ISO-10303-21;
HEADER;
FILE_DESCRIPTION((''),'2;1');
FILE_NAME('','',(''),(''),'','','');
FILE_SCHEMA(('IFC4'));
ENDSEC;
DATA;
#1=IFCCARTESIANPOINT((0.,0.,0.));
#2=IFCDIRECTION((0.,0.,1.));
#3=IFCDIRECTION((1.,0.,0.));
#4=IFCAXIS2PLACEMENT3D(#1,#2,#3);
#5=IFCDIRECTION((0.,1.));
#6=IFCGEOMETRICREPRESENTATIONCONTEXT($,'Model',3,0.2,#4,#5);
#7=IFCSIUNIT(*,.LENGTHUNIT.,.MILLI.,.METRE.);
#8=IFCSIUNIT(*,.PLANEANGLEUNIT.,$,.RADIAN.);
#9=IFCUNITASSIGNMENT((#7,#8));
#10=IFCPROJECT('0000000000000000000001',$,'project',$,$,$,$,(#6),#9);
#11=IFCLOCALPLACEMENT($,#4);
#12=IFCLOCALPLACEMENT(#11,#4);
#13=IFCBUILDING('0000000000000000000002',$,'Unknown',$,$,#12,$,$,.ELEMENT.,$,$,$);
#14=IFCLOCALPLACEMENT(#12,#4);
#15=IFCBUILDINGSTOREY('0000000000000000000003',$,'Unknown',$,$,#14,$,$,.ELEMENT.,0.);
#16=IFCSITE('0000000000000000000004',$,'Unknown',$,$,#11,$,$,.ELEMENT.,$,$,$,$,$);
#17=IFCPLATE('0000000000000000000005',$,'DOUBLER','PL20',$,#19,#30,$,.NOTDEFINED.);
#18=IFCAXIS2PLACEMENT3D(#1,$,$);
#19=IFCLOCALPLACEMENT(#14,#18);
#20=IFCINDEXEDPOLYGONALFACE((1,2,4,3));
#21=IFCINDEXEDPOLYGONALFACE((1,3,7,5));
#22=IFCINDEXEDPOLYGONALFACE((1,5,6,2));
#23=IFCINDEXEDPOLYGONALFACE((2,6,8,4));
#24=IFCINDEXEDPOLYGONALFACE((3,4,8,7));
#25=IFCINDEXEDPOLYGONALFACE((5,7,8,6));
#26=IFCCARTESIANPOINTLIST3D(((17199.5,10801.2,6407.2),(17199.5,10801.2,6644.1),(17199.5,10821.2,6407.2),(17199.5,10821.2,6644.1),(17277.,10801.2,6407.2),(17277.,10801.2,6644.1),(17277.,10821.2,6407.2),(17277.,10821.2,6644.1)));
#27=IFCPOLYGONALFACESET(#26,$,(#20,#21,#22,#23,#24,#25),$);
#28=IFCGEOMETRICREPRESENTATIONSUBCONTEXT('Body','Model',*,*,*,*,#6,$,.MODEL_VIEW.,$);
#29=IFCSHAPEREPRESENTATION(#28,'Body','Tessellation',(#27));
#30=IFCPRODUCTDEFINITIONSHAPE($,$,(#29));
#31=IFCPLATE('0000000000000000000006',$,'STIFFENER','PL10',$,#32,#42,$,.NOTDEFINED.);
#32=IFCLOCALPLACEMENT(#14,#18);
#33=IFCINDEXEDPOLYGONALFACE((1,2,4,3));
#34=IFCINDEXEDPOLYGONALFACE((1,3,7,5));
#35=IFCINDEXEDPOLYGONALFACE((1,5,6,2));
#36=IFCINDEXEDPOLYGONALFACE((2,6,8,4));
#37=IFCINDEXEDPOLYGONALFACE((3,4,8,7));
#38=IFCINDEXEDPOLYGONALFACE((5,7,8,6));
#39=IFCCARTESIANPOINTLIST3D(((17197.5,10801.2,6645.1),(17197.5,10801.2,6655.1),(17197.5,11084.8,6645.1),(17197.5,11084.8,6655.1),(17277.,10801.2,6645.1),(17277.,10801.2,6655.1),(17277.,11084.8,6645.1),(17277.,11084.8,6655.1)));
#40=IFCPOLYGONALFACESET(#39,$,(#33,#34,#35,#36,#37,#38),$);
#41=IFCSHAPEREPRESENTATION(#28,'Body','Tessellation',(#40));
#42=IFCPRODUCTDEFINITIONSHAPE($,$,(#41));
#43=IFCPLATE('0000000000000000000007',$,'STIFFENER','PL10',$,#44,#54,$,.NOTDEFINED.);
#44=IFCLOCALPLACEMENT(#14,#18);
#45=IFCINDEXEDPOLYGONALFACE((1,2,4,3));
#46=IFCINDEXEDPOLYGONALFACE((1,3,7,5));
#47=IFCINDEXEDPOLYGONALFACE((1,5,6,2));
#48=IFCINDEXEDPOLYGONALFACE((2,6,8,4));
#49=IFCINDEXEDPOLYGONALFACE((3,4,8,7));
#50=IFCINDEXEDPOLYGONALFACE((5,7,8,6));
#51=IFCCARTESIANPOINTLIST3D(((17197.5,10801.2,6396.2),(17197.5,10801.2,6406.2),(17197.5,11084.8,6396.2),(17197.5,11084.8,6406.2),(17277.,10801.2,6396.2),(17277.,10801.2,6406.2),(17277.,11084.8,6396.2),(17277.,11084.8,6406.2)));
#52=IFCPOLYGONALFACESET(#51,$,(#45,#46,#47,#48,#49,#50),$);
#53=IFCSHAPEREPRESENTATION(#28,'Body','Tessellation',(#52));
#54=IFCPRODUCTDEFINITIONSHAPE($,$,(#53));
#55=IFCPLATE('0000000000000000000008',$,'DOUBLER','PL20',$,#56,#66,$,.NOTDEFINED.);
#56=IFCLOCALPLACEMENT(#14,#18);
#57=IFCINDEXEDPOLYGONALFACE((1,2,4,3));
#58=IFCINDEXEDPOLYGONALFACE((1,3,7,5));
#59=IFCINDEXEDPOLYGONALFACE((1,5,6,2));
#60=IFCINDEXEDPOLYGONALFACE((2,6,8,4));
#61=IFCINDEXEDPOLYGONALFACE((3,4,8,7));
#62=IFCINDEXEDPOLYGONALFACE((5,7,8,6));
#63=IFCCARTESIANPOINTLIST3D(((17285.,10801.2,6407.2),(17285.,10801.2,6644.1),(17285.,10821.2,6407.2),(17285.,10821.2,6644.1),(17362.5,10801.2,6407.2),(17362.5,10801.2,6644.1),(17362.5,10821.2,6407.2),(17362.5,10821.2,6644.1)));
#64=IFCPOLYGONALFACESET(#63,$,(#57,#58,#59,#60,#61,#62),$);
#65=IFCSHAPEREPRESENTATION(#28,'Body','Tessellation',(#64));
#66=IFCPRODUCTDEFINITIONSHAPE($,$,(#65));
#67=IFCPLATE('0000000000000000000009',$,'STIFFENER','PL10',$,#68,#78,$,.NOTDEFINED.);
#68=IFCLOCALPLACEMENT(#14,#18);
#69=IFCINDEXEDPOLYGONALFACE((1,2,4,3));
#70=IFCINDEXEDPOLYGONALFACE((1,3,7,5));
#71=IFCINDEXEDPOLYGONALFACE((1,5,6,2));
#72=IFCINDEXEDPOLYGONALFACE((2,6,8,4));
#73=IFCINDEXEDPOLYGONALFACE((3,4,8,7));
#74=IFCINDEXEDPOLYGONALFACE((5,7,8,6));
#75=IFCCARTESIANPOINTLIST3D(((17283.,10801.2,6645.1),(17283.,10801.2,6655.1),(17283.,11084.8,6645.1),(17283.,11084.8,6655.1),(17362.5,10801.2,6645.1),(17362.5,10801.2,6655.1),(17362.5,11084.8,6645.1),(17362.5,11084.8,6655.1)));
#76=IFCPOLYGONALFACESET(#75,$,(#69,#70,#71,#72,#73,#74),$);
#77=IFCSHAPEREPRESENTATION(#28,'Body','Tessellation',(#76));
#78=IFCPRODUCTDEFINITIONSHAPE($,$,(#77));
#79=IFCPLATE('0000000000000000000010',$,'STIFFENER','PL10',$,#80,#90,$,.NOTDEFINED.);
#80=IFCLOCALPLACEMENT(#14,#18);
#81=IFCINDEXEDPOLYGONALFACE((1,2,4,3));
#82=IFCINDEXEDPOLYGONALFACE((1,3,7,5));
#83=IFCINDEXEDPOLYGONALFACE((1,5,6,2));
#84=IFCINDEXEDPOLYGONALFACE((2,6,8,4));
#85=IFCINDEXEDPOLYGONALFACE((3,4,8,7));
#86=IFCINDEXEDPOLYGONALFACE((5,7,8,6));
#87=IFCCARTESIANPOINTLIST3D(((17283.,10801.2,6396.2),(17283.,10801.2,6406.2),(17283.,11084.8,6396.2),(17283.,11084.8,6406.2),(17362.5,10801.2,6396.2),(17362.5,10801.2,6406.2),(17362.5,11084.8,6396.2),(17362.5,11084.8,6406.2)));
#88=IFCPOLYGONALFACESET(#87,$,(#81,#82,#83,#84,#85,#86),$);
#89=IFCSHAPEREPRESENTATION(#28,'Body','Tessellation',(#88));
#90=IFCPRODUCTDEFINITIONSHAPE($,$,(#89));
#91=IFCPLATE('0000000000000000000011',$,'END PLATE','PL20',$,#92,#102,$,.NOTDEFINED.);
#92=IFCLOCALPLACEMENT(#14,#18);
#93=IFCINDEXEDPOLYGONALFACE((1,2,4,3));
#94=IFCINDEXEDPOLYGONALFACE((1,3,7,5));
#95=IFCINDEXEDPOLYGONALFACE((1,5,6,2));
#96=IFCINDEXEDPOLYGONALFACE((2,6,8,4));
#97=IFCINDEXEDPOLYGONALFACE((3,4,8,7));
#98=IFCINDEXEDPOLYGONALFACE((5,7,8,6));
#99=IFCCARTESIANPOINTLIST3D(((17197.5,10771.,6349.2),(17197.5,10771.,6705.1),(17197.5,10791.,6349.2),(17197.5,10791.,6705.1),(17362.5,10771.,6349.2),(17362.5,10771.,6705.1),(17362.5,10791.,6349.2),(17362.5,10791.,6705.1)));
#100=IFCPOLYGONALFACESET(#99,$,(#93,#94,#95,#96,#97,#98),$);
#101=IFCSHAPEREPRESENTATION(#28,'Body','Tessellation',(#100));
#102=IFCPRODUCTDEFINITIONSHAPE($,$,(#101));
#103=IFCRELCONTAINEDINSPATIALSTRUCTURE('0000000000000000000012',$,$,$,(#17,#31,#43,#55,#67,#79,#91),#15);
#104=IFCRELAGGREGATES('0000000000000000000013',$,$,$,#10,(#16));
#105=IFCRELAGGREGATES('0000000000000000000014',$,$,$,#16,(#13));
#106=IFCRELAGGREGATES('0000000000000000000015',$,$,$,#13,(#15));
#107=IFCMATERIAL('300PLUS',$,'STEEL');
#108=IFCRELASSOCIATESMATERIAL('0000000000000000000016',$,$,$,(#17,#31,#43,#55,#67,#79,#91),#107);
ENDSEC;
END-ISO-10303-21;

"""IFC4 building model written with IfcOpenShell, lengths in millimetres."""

from ifc_helpers import new_model, si_unit, direction, frame, origin_with_axes, place, context, subcontext, project, spatial, line, indexed_curve, outline, extrude, material, element, save


model = new_model("IFC4")

# Units and contexts
model_context = context("Model", 3, precision=0.2, world=origin_with_axes(), true_north=direction((0.0, 1.0)))
body_context = subcontext(model_context, "Body", "Model", "MODEL_VIEW")
ifc_project = project(units=[si_unit("LENGTHUNIT", "METRE", prefix="MILLI"), si_unit("PLANEANGLEUNIT", "RADIAN")], contexts=[model_context])

# Site, building, storey
site_placement = place(None, origin_with_axes())
site = spatial("IfcSite", under=ifc_project, at=site_placement, Name="Unknown", CompositionType="ELEMENT")
building_placement = place(site_placement, origin_with_axes())
building = spatial("IfcBuilding", under=site, at=building_placement, Name="Unknown", CompositionType="ELEMENT")
storey_placement = place(building_placement, origin_with_axes())
storey = spatial("IfcBuildingStorey", under=building, at=storey_placement, Name="Unknown", CompositionType="ELEMENT", Elevation=0.0)

# Shared definitions
ifc_material_1 = material(Name="300PLUS", Category="STEEL")

# Plates
plate_1_placement = place(storey_placement, frame((17199.5, 10811.2, 6407.2), z_axis=(0.0, -1.0, 0.0), x_axis=(1.0, 0.0, 0.0)))
element("IfcPlate", 1, at=plate_1_placement, inside=storey, material=ifc_material_1, Name="DOUBLER", Description="PL20", PredefinedType="NOTDEFINED", context=body_context, shape_type="SolidModel", body=[
    extrude(outline(indexed_curve([(0.0, 0.0), (77.5, 0.0), (77.5, 236.9), (0.0, 236.9)], segments=[line(1, 2, 3, 4, 1)])), frame((0.0, 0.0, 10.0), z_axis=(0.0, 0.0, 1.0), x_axis=(1.0, 0.0, 0.0)), (0.0, 0.0, -1.0), 20.0),
])
for number, where, z_axis, x_axis, name in (
    (2, (17197.5, 10801.2, 6650.1), (0.0, 0.0, 1.0), (1.0, 0.0, 0.0), "STIFFENER"),
    (3, (17197.5, 10801.2, 6401.2), (0.0, 0.0, 1.0), (1.0, 0.0, 0.0), "STIFFENER"),
):
    element("IfcPlate", number, at=place(storey_placement, frame(where, z_axis=z_axis, x_axis=x_axis)), inside=storey, material=ifc_material_1, Name=name, Description="PL10", PredefinedType="NOTDEFINED", context=body_context, shape_type="SolidModel", body=[
        extrude(outline(indexed_curve([(0.0, 0.0), (79.5, 0.0), (79.5, 283.6), (0.0, 283.6)], segments=[line(1, 2, 3, 4, 1)])), frame((0.0, 0.0, 5.0), z_axis=(0.0, 0.0, 1.0), x_axis=(1.0, 0.0, 0.0)), (0.0, 0.0, -1.0), 10.0),
    ])
plate_2_placement = place(storey_placement, frame((17285.0, 10811.2, 6407.2), z_axis=(0.0, -1.0, 0.0), x_axis=(1.0, 0.0, 0.0)))
element("IfcPlate", 4, at=plate_2_placement, inside=storey, material=ifc_material_1, Name="DOUBLER", Description="PL20", PredefinedType="NOTDEFINED", context=body_context, shape_type="SolidModel", body=[
    extrude(outline(indexed_curve([(0.0, 0.0), (77.5, 0.0), (77.5, 236.9), (0.0, 236.9)], segments=[line(1, 2, 3, 4, 1)])), frame((0.0, 0.0, 10.0), z_axis=(0.0, 0.0, 1.0), x_axis=(1.0, 0.0, 0.0)), (0.0, 0.0, -1.0), 20.0),
])
for number, where, z_axis, x_axis, name in (
    (5, (17283.0, 10801.2, 6650.1), (0.0, 0.0, 1.0), (1.0, 0.0, 0.0), "STIFFENER"),
    (6, (17283.0, 10801.2, 6401.2), (0.0, 0.0, 1.0), (1.0, 0.0, 0.0), "STIFFENER"),
):
    element("IfcPlate", number, at=place(storey_placement, frame(where, z_axis=z_axis, x_axis=x_axis)), inside=storey, material=ifc_material_1, Name=name, Description="PL10", PredefinedType="NOTDEFINED", context=body_context, shape_type="SolidModel", body=[
        extrude(outline(indexed_curve([(0.0, 0.0), (79.5, 0.0), (79.5, 283.6), (0.0, 283.6)], segments=[line(1, 2, 3, 4, 1)])), frame((0.0, 0.0, 5.0), z_axis=(0.0, 0.0, 1.0), x_axis=(1.0, 0.0, 0.0)), (0.0, 0.0, -1.0), 10.0),
    ])
plate_3_placement = place(storey_placement, frame((17197.5, 10781.0, 6349.2), z_axis=(0.0, -1.0, 0.0), x_axis=(1.0, 0.0, 0.0)))
element("IfcPlate", 7, at=plate_3_placement, inside=storey, material=ifc_material_1, Name="END PLATE", Description="PL20", PredefinedType="NOTDEFINED", context=body_context, shape_type="SolidModel", body=[
    extrude(outline(indexed_curve([(0.0, 0.0), (165.0, 0.0), (165.0, 355.9), (0.0, 355.9)], segments=[line(1, 2, 3, 4, 1)])), frame((0.0, 0.0, 10.0), z_axis=(0.0, 0.0, 1.0), x_axis=(1.0, 0.0, 0.0)), (0.0, 0.0, -1.0), 20.0),
])

save(model, "model.ifc")
